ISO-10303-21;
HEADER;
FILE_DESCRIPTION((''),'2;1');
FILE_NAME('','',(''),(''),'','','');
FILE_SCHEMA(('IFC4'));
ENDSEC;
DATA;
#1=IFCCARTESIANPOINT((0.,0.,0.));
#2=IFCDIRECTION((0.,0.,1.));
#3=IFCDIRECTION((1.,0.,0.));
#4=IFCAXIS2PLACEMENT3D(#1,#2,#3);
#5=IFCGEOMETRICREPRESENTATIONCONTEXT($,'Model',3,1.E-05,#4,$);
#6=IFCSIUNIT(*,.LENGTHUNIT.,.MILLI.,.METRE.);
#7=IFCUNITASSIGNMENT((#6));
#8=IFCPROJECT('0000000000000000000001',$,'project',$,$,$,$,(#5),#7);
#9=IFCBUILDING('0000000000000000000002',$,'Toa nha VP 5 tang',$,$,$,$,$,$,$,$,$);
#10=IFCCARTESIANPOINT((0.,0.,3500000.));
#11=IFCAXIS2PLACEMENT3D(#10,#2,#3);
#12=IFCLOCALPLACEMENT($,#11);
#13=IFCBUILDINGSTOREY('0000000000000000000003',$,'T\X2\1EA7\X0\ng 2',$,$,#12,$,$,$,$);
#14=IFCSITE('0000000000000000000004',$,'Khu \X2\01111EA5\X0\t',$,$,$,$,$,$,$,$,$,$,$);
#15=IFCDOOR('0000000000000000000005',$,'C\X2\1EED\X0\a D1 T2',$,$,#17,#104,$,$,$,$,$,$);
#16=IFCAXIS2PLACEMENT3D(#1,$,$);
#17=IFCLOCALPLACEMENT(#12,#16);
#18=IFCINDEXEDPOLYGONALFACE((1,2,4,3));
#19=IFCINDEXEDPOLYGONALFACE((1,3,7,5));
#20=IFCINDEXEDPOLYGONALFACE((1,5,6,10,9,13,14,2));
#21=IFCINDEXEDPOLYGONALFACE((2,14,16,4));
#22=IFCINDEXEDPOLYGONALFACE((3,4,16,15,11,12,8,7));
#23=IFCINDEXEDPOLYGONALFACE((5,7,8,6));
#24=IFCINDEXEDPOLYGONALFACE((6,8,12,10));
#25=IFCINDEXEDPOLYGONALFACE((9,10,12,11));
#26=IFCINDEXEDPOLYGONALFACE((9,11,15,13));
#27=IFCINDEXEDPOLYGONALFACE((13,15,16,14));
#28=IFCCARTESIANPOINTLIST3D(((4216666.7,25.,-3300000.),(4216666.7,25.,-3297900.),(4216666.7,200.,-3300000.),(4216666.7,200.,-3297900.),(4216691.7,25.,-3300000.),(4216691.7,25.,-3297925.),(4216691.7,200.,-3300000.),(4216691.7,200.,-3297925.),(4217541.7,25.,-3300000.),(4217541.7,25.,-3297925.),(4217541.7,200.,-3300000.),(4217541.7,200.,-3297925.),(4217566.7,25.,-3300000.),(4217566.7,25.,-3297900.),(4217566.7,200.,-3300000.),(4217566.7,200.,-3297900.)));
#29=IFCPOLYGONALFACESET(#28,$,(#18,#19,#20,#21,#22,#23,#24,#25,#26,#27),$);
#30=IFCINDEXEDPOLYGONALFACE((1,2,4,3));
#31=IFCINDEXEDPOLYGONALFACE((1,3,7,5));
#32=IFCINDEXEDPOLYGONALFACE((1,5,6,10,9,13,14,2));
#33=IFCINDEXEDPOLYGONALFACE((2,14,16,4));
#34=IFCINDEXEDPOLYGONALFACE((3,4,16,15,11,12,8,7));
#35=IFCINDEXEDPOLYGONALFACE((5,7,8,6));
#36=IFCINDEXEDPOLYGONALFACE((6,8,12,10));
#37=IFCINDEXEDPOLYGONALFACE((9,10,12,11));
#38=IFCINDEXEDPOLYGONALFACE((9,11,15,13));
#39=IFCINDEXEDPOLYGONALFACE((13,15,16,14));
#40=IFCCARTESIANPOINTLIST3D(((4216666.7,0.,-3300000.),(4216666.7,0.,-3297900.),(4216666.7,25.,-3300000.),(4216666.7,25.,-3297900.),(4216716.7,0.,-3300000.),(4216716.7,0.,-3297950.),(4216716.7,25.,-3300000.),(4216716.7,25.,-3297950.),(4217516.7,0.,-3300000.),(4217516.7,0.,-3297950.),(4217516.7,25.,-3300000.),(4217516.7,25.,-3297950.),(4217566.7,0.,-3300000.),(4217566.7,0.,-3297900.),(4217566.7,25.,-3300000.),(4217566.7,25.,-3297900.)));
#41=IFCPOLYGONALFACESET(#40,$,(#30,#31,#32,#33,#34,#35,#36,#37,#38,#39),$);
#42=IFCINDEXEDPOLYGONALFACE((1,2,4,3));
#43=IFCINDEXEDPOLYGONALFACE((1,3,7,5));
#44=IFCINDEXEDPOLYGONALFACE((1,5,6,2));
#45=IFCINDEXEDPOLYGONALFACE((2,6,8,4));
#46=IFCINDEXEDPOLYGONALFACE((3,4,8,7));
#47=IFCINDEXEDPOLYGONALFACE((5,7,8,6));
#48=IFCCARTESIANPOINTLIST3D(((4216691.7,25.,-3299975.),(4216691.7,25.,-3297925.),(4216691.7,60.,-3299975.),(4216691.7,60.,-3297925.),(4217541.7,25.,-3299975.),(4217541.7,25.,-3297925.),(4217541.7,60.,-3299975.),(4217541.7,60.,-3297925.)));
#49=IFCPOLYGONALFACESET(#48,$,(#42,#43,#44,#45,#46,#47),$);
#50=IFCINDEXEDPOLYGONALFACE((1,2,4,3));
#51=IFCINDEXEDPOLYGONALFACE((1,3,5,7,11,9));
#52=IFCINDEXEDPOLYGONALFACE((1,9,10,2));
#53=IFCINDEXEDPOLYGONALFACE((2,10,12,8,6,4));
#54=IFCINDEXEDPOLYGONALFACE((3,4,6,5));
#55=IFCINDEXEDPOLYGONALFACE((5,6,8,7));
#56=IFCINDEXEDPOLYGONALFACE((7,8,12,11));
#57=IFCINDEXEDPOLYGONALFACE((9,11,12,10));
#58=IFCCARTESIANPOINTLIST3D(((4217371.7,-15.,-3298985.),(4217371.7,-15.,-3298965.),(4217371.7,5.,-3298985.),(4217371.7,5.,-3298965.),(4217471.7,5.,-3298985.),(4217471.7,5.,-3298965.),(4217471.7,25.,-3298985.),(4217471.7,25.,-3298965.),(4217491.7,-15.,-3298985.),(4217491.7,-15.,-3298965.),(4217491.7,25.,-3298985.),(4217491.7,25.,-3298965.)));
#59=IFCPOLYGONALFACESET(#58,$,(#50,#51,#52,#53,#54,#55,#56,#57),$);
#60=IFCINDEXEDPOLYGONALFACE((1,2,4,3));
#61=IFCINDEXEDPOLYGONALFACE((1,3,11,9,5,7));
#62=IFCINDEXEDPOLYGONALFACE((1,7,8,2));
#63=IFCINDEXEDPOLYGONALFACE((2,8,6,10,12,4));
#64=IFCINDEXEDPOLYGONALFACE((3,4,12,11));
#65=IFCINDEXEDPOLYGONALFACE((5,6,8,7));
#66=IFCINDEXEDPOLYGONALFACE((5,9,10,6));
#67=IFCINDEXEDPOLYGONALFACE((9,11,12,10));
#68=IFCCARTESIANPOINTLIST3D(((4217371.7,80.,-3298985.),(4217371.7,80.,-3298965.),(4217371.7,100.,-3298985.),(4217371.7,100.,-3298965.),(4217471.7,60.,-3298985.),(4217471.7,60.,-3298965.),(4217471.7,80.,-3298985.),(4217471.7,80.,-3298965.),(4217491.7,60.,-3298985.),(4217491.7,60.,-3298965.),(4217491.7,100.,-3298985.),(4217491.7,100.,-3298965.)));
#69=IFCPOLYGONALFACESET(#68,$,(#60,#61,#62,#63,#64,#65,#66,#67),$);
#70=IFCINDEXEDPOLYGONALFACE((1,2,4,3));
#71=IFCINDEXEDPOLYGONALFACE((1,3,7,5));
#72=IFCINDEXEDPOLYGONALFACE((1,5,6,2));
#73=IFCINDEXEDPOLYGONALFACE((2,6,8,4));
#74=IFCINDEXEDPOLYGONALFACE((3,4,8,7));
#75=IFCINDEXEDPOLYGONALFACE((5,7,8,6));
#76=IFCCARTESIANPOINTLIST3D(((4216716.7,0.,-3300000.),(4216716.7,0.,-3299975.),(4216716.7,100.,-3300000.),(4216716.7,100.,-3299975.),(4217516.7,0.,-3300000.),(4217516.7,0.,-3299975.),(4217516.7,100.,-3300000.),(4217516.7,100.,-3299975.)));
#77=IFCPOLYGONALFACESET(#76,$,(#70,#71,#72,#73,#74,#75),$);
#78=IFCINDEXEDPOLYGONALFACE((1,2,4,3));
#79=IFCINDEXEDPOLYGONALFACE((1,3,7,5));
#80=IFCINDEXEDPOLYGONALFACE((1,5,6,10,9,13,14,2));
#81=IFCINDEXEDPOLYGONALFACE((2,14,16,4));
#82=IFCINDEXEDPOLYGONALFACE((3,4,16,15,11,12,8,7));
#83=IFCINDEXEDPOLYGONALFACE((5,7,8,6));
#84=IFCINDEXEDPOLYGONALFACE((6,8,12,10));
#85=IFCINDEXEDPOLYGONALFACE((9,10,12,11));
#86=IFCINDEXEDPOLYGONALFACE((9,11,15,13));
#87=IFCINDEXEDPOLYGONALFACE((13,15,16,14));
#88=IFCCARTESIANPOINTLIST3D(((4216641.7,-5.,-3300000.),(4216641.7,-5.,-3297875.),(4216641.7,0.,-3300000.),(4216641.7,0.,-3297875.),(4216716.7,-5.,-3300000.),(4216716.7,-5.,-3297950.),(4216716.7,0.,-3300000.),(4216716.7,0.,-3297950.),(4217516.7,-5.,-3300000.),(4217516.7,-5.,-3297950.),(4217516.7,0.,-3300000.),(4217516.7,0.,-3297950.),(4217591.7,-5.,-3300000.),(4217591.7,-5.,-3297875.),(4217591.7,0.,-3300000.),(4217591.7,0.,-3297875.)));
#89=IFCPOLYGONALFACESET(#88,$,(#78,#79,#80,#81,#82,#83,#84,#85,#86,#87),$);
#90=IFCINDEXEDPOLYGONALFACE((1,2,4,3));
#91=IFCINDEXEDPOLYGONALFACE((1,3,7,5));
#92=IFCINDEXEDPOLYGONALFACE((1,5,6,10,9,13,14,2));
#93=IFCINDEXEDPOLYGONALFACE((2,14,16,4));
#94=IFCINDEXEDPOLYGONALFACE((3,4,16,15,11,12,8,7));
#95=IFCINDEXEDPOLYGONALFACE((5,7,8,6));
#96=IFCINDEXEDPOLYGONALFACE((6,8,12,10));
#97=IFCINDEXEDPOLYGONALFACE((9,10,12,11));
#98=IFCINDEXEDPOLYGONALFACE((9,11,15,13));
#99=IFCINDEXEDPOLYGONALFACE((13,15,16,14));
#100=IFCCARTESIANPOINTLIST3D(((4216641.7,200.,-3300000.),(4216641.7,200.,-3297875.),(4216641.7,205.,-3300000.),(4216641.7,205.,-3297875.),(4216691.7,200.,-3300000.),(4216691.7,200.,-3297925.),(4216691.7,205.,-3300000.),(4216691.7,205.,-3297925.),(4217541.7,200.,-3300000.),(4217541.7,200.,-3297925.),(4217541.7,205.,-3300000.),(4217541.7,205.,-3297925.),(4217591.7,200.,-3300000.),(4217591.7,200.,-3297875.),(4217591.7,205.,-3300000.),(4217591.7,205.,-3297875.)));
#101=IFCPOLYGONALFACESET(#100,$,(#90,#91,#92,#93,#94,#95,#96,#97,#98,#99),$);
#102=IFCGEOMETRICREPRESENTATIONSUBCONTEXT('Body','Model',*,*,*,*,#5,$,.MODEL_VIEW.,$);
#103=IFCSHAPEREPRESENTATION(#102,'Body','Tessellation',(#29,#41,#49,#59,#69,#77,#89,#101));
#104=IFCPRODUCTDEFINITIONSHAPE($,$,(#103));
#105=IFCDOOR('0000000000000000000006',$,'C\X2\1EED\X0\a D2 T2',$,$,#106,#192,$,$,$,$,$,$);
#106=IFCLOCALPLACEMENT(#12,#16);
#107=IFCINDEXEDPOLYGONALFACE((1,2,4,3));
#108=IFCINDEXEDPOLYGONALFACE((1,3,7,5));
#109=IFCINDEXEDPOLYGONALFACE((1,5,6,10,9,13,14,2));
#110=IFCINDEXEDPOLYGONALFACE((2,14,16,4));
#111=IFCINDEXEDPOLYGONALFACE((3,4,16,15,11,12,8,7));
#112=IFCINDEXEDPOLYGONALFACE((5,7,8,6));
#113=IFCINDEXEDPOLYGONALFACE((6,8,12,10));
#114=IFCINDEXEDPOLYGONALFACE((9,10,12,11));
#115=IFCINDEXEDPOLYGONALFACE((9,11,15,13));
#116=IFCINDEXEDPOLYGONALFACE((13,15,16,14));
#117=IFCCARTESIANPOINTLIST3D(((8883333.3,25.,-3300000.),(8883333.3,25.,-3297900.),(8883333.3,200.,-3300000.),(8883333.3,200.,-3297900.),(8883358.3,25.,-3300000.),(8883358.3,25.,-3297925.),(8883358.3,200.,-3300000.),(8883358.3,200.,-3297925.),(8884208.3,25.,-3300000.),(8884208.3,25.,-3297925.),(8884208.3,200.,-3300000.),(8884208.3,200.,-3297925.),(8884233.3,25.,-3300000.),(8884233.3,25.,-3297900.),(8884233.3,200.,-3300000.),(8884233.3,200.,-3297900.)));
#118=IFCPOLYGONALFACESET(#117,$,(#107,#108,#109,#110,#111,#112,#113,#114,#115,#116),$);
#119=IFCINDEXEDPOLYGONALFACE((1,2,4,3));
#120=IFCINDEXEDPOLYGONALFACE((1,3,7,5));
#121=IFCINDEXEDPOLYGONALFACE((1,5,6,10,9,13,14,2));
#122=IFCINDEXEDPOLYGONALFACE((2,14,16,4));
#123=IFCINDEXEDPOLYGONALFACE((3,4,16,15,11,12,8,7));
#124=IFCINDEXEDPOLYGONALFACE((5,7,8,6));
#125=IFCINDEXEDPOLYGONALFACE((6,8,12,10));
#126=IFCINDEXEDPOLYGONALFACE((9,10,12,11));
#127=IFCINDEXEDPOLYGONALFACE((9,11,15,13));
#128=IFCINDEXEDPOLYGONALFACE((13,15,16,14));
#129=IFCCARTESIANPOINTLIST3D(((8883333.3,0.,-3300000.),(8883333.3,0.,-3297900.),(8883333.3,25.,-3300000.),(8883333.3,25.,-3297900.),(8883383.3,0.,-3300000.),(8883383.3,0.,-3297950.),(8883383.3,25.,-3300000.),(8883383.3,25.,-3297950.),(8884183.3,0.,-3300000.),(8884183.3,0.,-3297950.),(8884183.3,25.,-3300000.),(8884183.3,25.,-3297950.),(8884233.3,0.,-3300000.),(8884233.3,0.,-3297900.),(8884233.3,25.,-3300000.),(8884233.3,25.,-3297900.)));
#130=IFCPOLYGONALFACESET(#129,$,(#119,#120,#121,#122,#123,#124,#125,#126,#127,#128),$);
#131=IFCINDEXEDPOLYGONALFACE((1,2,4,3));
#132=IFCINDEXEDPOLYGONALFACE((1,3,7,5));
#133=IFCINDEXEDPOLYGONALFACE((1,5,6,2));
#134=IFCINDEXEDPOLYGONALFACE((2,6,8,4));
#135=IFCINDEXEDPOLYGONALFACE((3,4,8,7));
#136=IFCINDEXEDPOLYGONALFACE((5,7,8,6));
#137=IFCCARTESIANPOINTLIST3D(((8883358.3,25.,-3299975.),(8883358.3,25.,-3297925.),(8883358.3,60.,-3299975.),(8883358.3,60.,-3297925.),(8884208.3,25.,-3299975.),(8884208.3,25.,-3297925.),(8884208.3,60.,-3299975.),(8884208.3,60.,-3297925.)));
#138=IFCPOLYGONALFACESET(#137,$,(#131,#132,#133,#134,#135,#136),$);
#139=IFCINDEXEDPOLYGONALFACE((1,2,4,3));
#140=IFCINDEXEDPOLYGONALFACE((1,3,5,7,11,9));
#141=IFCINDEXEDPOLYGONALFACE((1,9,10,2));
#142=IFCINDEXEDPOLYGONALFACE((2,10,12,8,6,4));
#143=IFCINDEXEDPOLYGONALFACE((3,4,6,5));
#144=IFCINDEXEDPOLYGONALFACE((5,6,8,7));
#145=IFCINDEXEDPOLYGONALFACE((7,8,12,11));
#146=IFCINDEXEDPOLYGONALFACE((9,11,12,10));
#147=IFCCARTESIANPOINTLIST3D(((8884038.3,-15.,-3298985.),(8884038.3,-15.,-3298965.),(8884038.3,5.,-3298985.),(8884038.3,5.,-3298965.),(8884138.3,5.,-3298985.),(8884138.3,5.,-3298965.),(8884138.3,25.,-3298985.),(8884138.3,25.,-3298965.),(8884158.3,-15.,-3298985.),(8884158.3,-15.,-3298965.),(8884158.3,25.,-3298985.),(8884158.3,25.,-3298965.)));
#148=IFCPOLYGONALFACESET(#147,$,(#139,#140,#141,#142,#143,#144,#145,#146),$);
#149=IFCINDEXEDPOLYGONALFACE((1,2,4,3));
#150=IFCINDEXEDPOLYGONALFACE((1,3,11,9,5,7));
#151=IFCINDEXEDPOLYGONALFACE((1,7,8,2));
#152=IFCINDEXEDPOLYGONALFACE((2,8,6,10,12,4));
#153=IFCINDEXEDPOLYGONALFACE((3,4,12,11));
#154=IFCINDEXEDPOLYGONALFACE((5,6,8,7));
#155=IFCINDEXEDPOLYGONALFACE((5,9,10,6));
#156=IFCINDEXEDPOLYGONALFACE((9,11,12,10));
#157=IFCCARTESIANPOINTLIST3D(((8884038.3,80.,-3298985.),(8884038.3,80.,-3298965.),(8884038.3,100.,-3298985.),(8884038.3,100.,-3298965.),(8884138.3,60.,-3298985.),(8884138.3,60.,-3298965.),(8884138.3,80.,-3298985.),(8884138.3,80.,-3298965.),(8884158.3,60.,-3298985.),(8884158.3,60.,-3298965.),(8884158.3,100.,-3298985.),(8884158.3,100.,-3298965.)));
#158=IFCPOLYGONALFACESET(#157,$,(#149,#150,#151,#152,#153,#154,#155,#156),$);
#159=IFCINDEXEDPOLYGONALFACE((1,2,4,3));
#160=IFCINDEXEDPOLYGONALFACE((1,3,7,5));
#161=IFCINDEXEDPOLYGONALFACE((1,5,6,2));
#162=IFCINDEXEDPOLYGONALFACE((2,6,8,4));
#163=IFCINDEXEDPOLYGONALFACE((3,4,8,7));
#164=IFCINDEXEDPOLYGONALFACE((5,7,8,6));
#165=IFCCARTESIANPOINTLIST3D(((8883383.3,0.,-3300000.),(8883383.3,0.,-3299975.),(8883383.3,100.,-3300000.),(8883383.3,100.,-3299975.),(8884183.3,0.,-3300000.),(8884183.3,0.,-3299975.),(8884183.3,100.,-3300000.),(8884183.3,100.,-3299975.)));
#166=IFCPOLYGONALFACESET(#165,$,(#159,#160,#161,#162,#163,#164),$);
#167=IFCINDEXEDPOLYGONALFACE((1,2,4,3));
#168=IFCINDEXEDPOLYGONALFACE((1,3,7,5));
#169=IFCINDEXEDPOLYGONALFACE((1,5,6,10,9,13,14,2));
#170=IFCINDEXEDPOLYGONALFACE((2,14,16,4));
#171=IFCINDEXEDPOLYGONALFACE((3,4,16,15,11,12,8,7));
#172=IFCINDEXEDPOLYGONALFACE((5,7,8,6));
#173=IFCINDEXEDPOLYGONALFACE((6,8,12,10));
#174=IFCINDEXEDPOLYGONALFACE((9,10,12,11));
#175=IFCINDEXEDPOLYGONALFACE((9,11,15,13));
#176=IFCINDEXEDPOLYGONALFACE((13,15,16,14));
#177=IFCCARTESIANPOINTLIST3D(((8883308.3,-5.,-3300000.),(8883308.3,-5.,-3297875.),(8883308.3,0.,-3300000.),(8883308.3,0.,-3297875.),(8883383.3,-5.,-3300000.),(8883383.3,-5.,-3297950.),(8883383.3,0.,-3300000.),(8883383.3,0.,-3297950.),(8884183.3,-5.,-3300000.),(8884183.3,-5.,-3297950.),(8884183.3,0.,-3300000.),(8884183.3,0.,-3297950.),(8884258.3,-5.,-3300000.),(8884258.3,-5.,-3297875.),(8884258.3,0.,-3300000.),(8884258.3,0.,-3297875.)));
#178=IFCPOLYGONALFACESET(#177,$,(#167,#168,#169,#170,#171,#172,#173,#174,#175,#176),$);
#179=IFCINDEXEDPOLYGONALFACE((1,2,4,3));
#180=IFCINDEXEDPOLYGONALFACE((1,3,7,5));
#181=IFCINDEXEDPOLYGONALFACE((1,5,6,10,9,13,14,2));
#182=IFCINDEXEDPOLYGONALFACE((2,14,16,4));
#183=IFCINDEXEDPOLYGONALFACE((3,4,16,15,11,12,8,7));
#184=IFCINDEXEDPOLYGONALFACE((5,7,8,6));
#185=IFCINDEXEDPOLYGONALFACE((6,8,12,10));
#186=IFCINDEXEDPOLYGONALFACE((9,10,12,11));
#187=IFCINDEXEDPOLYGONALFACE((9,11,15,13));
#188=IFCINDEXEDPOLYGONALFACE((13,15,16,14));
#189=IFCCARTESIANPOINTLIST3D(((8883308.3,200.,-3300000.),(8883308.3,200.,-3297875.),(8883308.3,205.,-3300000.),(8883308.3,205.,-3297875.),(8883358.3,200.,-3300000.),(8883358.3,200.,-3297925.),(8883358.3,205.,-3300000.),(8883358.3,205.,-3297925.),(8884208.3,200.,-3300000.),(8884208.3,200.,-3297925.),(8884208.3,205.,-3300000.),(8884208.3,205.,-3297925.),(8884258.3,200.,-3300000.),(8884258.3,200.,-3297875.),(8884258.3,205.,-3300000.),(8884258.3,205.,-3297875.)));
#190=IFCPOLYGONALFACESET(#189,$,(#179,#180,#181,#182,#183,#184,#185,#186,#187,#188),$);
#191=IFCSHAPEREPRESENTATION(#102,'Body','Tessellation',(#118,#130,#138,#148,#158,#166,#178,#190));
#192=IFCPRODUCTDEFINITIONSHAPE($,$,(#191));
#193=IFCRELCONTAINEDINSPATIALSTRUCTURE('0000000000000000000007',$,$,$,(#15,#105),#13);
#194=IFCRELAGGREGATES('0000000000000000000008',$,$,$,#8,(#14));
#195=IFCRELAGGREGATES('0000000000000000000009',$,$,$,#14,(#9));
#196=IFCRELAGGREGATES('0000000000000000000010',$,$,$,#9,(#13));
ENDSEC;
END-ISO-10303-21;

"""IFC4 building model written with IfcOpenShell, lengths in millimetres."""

from ifc_helpers import new_model, si_unit, frame, origin_with_axes, place, context, subcontext, project, spatial, line, indexed_curve, outline, extrude, element, save


model = new_model("IFC4")

# Units and contexts
model_context = context("Model", 3, precision=1e-05, world=origin_with_axes())
body_context = subcontext(model_context, "Body", "Model", "MODEL_VIEW")
ifc_project = project(units=[si_unit("LENGTHUNIT", "METRE", prefix="MILLI")], contexts=[model_context])

# Site, building, storey
site = spatial("IfcSite", under=ifc_project, Name="Khu đất")
building = spatial("IfcBuilding", under=site, Name="Toa nha VP 5 tang")
storey_placement = place(None, frame((0.0, 0.0, 3500000.0), z_axis=(0.0, 0.0, 1.0), x_axis=(1.0, 0.0, 0.0)))
storey = spatial("IfcBuildingStorey", under=building, at=storey_placement, Name="Tầng 2")

# Doors
door_1_placement = place(storey_placement, frame((4216666.7, 0.0, -3300000.0), z_axis=(0.0, 0.0, 1.0), x_axis=(1.0, 0.0, 0.0)))
element("IfcDoor", 1, at=door_1_placement, inside=storey, Name="Cửa D1 T2", context=body_context, shape_type="SolidModel", body=[
    extrude(outline(indexed_curve([(0.0, 0.0), (0.0, 2100.0), (900.0, 2100.0), (900.0, 0.0), (875.0, 0.0), (875.0, 2075.0), (25.0, 2075.0), (25.0, 0.0)], segments=[line(1, 2, 3, 4, 5, 6, 7, 8, 1)])), frame((0.0, 25.0, 0.0), z_axis=(0.0, -1.0, 0.0), x_axis=(1.0, 0.0, 0.0)), (0.0, 0.0, -1.0), 175.0),
    extrude(outline(indexed_curve([(0.0, 0.0), (0.0, 2100.0), (900.0, 2100.0), (900.0, 0.0), (850.0, 0.0), (850.0, 2050.0), (50.0, 2050.0), (50.0, 0.0)], segments=[line(1, 2, 3, 4, 5, 6, 7, 8, 1)])), frame((0.0, 0.0, 0.0), z_axis=(0.0, -1.0, 0.0), x_axis=(1.0, 0.0, 0.0)), (0.0, 0.0, -1.0), 25.0),
    extrude(outline(indexed_curve([(0.0, 0.0), (850.0, 0.0), (850.0, 35.0), (0.0, 35.0)], segments=[line(1, 2, 3, 4, 1)])), frame((25.0, 25.0, 25.0), z_axis=(0.0, 0.0, 1.0), x_axis=(1.0, 0.0, 0.0)), (0.0, 0.0, 1.0), 2050.0),
    extrude(outline(indexed_curve([(0.0, 0.0), (0.0, -40.0), (-120.0, -40.0), (-120.0, -20.0), (-20.0, -20.0), (-20.0, 0.0)], segments=[line(1, 2, 3, 4, 5, 6, 1)])), frame((825.0, 25.0, 1015.0), z_axis=(0.0, 0.0, 1.0), x_axis=(1.0, 0.0, 0.0)), (0.0, 0.0, 1.0), 20.0),
    extrude(outline(indexed_curve([(0.0, 0.0), (0.0, 40.0), (-120.0, 40.0), (-120.0, 20.0), (-20.0, 20.0), (-20.0, 0.0)], segments=[line(1, 2, 3, 4, 5, 6, 1)])), frame((825.0, 60.0, 1015.0), z_axis=(0.0, 0.0, 1.0), x_axis=(1.0, 0.0, 0.0)), (0.0, 0.0, 1.0), 20.0),
    extrude(outline(indexed_curve([(0.0, 0.0), (800.0, 0.0), (800.0, 100.0), (0.0, 100.0)], segments=[line(1, 2, 3, 4, 1)])), frame((50.0, 0.0, 0.0), z_axis=(0.0, 0.0, 1.0), x_axis=(1.0, 0.0, 0.0)), (0.0, 0.0, 1.0), 25.0),
    extrude(outline(indexed_curve([(0.0, 0.0), (0.0, 2125.0), (950.0, 2125.0), (950.0, 0.0), (875.0, 0.0), (875.0, 2050.0), (75.0, 2050.0), (75.0, 0.0)], segments=[line(1, 2, 3, 4, 5, 6, 7, 8, 1)])), frame((-25.0, -5.0, 0.0), z_axis=(0.0, -1.0, 0.0), x_axis=(1.0, 0.0, 0.0)), (0.0, 0.0, -1.0), 5.0),
    extrude(outline(indexed_curve([(0.0, 0.0), (0.0, 2125.0), (950.0, 2125.0), (950.0, 0.0), (900.0, 0.0), (900.0, 2075.0), (50.0, 2075.0), (50.0, 0.0)], segments=[line(1, 2, 3, 4, 5, 6, 7, 8, 1)])), frame((-25.0, 200.0, 0.0), z_axis=(0.0, -1.0, 0.0), x_axis=(1.0, 0.0, 0.0)), (0.0, 0.0, -1.0), 5.0),
])
door_2_placement = place(storey_placement, frame((8883333.3, 0.0, -3300000.0), z_axis=(0.0, 0.0, 1.0), x_axis=(1.0, 0.0, 0.0)))
element("IfcDoor", 2, at=door_2_placement, inside=storey, Name="Cửa D2 T2", context=body_context, shape_type="SolidModel", body=[
    extrude(outline(indexed_curve([(0.0, 0.0), (0.0, 2100.0), (900.0, 2100.0), (900.0, 0.0), (875.0, 0.0), (875.0, 2075.0), (25.0, 2075.0), (25.0, 0.0)], segments=[line(1, 2, 3, 4, 5, 6, 7, 8, 1)])), frame((0.0, 25.0, 0.0), z_axis=(0.0, -1.0, 0.0), x_axis=(1.0, 0.0, 0.0)), (0.0, 0.0, -1.0), 175.0),
    extrude(outline(indexed_curve([(0.0, 0.0), (0.0, 2100.0), (900.0, 2100.0), (900.0, 0.0), (850.0, 0.0), (850.0, 2050.0), (50.0, 2050.0), (50.0, 0.0)], segments=[line(1, 2, 3, 4, 5, 6, 7, 8, 1)])), frame((0.0, 0.0, 0.0), z_axis=(0.0, -1.0, 0.0), x_axis=(1.0, 0.0, 0.0)), (0.0, 0.0, -1.0), 25.0),
    extrude(outline(indexed_curve([(0.0, 0.0), (850.0, 0.0), (850.0, 35.0), (0.0, 35.0)], segments=[line(1, 2, 3, 4, 1)])), frame((25.0, 25.0, 25.0), z_axis=(0.0, 0.0, 1.0), x_axis=(1.0, 0.0, 0.0)), (0.0, 0.0, 1.0), 2050.0),
    extrude(outline(indexed_curve([(0.0, 0.0), (0.0, -40.0), (-120.0, -40.0), (-120.0, -20.0), (-20.0, -20.0), (-20.0, 0.0)], segments=[line(1, 2, 3, 4, 5, 6, 1)])), frame((825.0, 25.0, 1015.0), z_axis=(0.0, 0.0, 1.0), x_axis=(1.0, 0.0, 0.0)), (0.0, 0.0, 1.0), 20.0),
    extrude(outline(indexed_curve([(0.0, 0.0), (0.0, 40.0), (-120.0, 40.0), (-120.0, 20.0), (-20.0, 20.0), (-20.0, 0.0)], segments=[line(1, 2, 3, 4, 5, 6, 1)])), frame((825.0, 60.0, 1015.0), z_axis=(0.0, 0.0, 1.0), x_axis=(1.0, 0.0, 0.0)), (0.0, 0.0, 1.0), 20.0),
    extrude(outline(indexed_curve([(0.0, 0.0), (800.0, 0.0), (800.0, 100.0), (0.0, 100.0)], segments=[line(1, 2, 3, 4, 1)])), frame((50.0, 0.0, 0.0), z_axis=(0.0, 0.0, 1.0), x_axis=(1.0, 0.0, 0.0)), (0.0, 0.0, 1.0), 25.0),
    extrude(outline(indexed_curve([(0.0, 0.0), (0.0, 2125.0), (950.0, 2125.0), (950.0, 0.0), (875.0, 0.0), (875.0, 2050.0), (75.0, 2050.0), (75.0, 0.0)], segments=[line(1, 2, 3, 4, 5, 6, 7, 8, 1)])), frame((-25.0, -5.0, 0.0), z_axis=(0.0, -1.0, 0.0), x_axis=(1.0, 0.0, 0.0)), (0.0, 0.0, -1.0), 5.0),
    extrude(outline(indexed_curve([(0.0, 0.0), (0.0, 2125.0), (950.0, 2125.0), (950.0, 0.0), (900.0, 0.0), (900.0, 2075.0), (50.0, 2075.0), (50.0, 0.0)], segments=[line(1, 2, 3, 4, 5, 6, 7, 8, 1)])), frame((-25.0, 200.0, 0.0), z_axis=(0.0, -1.0, 0.0), x_axis=(1.0, 0.0, 0.0)), (0.0, 0.0, -1.0), 5.0),
])

save(model, "model.ifc")
